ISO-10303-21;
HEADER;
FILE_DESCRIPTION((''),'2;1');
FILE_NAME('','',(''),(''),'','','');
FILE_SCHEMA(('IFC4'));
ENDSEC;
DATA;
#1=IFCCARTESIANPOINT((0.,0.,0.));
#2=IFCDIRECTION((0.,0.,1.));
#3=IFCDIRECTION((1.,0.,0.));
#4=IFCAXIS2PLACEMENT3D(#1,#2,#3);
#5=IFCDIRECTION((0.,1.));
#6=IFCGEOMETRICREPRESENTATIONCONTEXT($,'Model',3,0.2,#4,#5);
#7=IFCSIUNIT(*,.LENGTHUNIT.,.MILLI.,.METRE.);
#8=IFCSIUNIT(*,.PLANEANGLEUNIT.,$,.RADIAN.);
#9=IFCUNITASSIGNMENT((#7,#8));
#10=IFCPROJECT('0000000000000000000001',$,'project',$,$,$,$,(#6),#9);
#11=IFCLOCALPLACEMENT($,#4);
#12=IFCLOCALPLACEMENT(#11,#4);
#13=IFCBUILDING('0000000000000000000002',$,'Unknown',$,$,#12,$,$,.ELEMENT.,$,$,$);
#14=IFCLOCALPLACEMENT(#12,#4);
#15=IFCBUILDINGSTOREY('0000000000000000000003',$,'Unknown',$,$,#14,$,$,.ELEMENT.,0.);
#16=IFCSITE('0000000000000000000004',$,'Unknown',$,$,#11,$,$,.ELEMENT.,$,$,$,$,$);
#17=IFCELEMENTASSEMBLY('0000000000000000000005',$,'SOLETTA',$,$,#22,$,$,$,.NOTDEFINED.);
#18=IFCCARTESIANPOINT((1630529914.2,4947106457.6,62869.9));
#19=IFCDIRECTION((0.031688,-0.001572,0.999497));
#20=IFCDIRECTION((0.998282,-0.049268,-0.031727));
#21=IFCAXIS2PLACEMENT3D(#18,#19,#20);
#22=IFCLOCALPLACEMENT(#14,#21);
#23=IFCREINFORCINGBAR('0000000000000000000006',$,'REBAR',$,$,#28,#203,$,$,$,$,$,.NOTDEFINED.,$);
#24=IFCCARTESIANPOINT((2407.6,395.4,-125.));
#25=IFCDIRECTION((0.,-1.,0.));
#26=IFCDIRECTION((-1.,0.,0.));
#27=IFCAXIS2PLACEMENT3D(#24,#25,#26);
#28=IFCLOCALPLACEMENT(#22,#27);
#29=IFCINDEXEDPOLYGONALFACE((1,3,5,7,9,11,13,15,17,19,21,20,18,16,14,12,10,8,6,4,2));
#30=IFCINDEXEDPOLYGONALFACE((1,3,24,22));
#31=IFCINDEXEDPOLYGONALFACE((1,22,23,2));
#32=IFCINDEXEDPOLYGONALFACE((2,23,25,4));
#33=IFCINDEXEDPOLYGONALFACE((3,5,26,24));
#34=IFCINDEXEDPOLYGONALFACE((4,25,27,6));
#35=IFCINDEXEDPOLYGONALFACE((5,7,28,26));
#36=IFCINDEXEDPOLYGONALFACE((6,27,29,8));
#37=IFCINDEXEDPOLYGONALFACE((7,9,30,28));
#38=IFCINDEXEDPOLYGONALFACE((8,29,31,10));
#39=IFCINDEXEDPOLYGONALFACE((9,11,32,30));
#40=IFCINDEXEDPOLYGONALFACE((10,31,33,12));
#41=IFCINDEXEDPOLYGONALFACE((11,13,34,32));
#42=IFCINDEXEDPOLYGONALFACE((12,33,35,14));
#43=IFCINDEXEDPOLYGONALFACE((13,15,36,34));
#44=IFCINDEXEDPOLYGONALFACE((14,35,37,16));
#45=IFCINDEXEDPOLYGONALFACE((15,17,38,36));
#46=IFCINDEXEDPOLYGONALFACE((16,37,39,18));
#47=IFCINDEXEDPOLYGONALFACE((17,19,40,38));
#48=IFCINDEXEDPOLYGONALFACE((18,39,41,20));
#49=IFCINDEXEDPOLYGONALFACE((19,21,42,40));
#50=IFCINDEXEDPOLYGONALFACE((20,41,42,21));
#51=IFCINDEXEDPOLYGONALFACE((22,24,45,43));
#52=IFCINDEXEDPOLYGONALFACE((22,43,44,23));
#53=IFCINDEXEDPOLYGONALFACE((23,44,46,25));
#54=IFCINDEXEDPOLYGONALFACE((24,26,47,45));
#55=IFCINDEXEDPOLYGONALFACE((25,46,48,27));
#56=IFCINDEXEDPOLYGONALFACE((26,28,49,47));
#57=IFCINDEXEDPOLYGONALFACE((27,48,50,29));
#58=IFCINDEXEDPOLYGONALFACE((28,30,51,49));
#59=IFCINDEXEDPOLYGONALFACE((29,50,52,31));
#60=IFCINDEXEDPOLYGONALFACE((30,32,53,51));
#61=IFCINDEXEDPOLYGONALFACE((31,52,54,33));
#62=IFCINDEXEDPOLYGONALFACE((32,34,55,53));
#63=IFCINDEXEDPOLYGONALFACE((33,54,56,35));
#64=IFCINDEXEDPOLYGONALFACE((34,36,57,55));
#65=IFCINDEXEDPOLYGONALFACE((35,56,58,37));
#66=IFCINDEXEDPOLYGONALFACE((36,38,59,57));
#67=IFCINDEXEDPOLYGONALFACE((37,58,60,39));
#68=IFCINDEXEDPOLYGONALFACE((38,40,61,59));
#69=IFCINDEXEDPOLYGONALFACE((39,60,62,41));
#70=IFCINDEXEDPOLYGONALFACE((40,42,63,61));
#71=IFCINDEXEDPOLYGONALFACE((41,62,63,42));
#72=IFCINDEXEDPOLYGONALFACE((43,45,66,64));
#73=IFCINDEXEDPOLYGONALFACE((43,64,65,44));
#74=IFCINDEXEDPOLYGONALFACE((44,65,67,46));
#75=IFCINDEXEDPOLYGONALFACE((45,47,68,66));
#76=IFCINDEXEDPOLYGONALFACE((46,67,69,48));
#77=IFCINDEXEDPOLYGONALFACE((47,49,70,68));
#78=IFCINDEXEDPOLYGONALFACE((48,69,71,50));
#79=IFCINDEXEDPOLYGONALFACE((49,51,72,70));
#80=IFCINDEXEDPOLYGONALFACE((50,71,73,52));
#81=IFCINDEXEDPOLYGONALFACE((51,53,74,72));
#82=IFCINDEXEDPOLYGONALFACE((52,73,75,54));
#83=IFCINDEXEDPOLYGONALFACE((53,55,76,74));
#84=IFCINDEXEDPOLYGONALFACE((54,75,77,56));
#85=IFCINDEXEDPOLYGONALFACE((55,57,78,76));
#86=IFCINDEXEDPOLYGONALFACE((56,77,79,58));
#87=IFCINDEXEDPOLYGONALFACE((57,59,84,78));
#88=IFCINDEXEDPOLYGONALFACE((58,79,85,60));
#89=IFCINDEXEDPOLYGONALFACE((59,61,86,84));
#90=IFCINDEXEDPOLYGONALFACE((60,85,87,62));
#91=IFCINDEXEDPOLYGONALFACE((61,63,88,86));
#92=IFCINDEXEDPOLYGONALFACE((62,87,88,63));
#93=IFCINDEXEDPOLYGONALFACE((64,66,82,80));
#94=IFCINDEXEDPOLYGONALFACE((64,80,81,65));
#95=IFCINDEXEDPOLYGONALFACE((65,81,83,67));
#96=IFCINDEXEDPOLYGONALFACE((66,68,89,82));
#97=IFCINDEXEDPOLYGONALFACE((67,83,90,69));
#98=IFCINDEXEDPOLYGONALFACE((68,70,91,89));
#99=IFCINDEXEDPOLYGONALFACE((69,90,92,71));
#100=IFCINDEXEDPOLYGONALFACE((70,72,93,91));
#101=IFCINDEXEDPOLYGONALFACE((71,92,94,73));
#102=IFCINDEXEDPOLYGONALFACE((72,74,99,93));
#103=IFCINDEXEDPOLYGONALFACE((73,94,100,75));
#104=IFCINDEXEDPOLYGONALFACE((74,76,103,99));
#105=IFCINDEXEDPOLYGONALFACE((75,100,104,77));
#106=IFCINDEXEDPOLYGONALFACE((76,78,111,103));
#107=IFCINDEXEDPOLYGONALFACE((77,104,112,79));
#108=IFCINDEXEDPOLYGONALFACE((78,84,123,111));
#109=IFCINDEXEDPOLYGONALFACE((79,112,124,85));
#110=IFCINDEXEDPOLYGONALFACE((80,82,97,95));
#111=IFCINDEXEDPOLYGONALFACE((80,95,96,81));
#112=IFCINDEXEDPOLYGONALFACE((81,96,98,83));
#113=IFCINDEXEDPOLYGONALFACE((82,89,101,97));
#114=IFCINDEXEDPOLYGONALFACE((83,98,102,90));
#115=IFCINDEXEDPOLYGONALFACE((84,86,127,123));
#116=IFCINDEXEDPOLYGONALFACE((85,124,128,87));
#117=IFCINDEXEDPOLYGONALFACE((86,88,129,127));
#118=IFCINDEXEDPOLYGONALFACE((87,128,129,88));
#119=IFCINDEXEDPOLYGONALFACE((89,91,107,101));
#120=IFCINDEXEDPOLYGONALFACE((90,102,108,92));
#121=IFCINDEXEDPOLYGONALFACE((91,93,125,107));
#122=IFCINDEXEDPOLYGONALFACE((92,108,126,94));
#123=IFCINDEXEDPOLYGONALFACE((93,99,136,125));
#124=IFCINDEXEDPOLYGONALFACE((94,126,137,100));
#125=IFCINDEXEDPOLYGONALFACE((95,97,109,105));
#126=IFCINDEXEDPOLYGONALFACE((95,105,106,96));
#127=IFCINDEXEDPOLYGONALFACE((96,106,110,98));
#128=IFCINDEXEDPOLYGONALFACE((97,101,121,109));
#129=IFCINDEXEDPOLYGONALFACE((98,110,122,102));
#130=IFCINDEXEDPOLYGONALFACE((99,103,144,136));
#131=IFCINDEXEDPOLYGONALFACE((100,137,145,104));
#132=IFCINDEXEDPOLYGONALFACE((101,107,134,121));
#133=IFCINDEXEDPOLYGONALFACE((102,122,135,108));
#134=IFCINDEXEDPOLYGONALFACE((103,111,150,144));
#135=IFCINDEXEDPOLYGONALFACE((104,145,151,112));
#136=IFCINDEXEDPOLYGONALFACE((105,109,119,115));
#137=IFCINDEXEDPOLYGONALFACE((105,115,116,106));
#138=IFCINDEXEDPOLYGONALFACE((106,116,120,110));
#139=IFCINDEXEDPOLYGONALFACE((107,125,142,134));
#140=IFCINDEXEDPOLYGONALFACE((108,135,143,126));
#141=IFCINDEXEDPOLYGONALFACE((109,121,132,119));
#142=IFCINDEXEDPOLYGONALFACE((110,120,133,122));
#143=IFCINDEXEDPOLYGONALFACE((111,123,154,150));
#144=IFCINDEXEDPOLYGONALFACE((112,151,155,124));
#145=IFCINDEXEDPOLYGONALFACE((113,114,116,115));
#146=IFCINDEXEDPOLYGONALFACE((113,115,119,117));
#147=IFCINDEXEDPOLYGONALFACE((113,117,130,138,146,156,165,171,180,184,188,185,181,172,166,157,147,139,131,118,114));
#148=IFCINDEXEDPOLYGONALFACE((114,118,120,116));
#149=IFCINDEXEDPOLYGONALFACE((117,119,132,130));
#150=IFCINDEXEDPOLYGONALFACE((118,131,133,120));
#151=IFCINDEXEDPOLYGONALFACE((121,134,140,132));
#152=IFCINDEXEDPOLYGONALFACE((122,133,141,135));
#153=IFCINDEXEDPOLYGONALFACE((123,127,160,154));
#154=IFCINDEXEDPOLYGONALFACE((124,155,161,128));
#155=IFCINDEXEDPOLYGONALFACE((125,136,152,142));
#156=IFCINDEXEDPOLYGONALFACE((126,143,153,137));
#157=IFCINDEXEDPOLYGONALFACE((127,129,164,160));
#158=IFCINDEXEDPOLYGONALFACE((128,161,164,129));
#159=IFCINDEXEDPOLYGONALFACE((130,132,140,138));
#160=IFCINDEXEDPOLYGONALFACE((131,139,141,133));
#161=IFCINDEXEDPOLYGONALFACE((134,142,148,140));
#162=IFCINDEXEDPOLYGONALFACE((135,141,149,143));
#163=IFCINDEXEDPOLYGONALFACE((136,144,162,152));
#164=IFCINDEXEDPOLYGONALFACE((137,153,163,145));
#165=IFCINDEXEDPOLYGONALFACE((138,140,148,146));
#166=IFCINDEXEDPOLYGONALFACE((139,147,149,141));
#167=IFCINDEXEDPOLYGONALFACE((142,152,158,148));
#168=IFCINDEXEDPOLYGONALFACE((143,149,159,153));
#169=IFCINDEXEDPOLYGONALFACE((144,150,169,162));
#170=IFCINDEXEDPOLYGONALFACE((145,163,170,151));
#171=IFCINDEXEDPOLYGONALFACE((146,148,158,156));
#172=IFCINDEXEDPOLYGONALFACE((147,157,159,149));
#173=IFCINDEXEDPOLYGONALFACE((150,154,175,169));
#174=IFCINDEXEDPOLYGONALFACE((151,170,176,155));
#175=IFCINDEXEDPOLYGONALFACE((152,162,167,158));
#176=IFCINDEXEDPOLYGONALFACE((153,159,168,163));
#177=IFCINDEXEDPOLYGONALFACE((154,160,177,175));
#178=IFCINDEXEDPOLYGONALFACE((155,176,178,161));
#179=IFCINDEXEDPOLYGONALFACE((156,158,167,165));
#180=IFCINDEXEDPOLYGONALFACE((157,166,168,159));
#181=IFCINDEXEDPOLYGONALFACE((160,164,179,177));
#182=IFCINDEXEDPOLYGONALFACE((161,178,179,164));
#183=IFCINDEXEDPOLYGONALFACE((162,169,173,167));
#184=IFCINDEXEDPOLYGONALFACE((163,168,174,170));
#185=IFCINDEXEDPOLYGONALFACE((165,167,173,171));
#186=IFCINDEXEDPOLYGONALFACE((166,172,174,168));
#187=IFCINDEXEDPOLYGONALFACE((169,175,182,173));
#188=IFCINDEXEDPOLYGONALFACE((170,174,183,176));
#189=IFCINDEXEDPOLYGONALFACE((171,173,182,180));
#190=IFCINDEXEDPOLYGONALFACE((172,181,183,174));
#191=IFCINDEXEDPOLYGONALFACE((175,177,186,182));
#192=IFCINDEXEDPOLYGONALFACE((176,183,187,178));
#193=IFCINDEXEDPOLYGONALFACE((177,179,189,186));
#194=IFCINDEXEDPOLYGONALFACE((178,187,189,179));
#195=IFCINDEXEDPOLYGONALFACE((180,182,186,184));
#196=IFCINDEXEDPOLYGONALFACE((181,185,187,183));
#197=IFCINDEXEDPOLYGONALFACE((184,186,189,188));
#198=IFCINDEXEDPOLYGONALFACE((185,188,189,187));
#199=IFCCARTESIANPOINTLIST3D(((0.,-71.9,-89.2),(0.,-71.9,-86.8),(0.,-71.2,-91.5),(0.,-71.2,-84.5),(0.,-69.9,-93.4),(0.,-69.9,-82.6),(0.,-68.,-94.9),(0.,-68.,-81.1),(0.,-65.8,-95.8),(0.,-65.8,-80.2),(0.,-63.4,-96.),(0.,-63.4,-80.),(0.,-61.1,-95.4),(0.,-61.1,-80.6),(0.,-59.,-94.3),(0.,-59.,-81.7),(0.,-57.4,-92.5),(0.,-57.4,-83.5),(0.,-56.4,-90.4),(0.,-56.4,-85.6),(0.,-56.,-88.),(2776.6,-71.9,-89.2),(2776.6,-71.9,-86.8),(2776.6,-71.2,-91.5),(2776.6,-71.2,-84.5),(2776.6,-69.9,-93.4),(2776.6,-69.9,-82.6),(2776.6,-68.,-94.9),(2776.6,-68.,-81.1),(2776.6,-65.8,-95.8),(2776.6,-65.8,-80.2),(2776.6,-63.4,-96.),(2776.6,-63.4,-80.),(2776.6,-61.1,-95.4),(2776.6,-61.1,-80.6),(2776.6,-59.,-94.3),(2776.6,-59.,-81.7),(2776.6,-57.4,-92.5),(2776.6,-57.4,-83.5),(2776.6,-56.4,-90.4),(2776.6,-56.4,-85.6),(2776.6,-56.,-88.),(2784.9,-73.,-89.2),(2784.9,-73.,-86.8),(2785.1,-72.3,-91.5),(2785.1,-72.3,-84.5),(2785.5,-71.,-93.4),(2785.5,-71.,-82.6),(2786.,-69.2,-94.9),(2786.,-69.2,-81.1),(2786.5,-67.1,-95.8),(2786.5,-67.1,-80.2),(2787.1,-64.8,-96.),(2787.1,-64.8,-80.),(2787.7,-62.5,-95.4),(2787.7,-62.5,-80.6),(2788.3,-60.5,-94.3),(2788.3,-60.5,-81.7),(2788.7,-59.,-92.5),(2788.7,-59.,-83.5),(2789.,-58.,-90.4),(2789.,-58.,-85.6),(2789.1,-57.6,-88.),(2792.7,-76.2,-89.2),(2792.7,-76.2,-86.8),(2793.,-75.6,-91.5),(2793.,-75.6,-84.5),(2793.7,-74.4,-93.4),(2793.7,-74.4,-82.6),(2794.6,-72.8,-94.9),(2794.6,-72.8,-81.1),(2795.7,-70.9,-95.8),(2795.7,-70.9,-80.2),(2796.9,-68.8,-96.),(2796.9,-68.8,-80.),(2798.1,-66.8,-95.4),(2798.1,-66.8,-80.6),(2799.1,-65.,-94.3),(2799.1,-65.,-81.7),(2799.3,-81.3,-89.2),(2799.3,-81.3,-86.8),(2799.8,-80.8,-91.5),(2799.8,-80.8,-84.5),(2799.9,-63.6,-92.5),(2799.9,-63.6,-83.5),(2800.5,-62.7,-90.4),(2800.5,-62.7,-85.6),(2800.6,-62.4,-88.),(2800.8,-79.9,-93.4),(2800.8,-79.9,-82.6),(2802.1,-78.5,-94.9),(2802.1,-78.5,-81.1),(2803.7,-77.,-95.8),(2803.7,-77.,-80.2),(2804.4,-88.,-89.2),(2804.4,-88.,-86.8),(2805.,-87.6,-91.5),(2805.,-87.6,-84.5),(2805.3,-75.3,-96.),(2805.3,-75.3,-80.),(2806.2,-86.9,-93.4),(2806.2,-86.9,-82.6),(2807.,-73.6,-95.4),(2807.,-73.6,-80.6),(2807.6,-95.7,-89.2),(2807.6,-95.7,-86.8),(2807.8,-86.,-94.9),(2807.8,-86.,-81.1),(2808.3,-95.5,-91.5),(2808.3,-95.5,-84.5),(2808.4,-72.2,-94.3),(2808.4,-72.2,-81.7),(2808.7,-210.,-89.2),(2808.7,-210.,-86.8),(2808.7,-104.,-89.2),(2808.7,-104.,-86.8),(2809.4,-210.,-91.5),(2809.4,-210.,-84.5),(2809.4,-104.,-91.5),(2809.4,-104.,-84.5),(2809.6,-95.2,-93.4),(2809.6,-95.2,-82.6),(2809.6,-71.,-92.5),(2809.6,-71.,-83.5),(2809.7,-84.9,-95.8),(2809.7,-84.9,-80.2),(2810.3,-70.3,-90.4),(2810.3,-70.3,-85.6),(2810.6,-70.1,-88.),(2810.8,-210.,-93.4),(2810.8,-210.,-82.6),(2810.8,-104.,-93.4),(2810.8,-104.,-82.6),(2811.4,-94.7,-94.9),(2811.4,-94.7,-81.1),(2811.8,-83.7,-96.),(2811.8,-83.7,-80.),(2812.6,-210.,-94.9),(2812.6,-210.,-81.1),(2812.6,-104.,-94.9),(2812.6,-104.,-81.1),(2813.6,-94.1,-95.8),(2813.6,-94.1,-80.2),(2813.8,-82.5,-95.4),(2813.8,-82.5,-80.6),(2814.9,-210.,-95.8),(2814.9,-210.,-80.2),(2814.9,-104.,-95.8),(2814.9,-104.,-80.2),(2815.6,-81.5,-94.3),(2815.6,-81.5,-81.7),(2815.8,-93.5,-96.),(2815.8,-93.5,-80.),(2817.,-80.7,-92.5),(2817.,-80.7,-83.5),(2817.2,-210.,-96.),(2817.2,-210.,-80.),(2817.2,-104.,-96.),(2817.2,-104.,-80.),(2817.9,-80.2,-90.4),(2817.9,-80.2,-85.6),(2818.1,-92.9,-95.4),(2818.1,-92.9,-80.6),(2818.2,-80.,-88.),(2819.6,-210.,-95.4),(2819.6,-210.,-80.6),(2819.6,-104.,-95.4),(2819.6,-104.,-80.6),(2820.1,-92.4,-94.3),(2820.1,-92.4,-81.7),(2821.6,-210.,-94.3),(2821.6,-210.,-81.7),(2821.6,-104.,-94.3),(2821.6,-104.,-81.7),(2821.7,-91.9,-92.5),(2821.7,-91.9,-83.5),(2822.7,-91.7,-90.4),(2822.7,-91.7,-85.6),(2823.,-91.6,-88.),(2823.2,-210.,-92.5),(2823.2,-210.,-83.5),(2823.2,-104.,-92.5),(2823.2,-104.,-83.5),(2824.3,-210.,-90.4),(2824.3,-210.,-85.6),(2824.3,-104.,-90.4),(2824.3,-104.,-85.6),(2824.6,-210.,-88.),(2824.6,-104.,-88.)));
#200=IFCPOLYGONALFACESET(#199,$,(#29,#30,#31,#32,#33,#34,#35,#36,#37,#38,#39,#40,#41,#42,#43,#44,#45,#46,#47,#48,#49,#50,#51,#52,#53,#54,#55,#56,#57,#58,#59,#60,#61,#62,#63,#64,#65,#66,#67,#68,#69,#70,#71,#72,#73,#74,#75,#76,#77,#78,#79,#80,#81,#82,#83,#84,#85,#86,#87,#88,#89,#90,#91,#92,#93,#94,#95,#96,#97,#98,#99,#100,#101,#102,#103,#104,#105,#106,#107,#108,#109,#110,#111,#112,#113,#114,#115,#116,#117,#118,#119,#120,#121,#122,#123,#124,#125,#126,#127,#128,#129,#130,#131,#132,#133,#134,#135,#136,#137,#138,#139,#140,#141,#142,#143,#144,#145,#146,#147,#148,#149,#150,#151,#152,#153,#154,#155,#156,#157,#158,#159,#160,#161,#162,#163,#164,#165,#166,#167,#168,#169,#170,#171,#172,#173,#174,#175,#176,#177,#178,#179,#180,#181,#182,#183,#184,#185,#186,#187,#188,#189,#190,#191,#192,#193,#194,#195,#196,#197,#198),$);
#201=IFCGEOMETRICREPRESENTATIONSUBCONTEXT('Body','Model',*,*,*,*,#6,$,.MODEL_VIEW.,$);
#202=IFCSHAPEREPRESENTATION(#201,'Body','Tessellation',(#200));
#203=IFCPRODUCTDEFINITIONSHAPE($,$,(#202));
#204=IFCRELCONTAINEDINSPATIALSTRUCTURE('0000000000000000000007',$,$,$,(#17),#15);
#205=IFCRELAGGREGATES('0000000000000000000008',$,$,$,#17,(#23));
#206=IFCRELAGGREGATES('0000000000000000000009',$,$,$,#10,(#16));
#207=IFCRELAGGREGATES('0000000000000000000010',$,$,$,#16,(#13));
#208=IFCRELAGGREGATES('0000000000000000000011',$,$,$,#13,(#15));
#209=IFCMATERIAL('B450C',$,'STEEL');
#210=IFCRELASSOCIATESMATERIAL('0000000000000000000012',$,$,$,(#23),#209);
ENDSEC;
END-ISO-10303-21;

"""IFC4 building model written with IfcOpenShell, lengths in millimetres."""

from ifc_helpers import new_model, entity, si_unit, direction, frame, origin_with_axes, place, context, subcontext, project, spatial, material, element, aggregate, save


model = new_model("IFC4")

# Units and contexts
model_context = context("Model", 3, precision=0.2, world=origin_with_axes(), true_north=direction((0.0, 1.0)))
body_context = subcontext(model_context, "Body", "Model", "MODEL_VIEW")
ifc_project = project(units=[si_unit("LENGTHUNIT", "METRE", prefix="MILLI"), si_unit("PLANEANGLEUNIT", "RADIAN")], contexts=[model_context])

# Site, building, storey
site_placement = place(None, origin_with_axes())
site = spatial("IfcSite", under=ifc_project, at=site_placement, Name="Unknown", CompositionType="ELEMENT")
building_placement = place(site_placement, origin_with_axes())
building = spatial("IfcBuilding", under=site, at=building_placement, Name="Unknown", CompositionType="ELEMENT")
storey_placement = place(building_placement, origin_with_axes())
storey = spatial("IfcBuildingStorey", under=building, at=storey_placement, Name="Unknown", CompositionType="ELEMENT", Elevation=0.0)

# Element assembly
ifc_material = material(Name="B450C", Category="STEEL")
assembly_1_placement = place(storey_placement, frame((1630529914.2, 4947106457.6, 62869.9), z_axis=(0.031688, -0.001572, 0.999497), x_axis=(0.998282, -0.049268, -0.031727)))
assembly_1 = element("IfcElementAssembly", 1, at=assembly_1_placement, inside=storey, Name="SOLETTA", PredefinedType="NOTDEFINED")

# Reinforcing bar
reinforcing_bar_1_placement = place(assembly_1_placement, frame((2407.6, 395.4, -125.0), z_axis=(0.0, -1.0, 0.0), x_axis=(-1.0, 0.0, 0.0)))
reinforcing_bar_1 = element("IfcReinforcingBar", 2, at=reinforcing_bar_1_placement, material=ifc_material, Name="REBAR", PredefinedType="NOTDEFINED", context=body_context, shape_type="AdvancedSweptSolid", body=[
    entity("IfcSweptDiskSolid", entity("IfcIndexedPolyCurve", entity("IfcCartesianPointList3D", [[0.0, -64.0, -88.0], [2776.6, -64.0, -88.0], [2804.9, -75.7, -88.0], [2816.6, -104.0, -88.0], [2816.6, -210.0, -88.0]]), [entity("IfcLineIndex", [1, 2]), entity("IfcArcIndex", [2, 3, 4]), entity("IfcLineIndex", [4, 5])]), 8.0),
])
aggregate(assembly_1, [reinforcing_bar_1])

save(model, "model.ifc")
